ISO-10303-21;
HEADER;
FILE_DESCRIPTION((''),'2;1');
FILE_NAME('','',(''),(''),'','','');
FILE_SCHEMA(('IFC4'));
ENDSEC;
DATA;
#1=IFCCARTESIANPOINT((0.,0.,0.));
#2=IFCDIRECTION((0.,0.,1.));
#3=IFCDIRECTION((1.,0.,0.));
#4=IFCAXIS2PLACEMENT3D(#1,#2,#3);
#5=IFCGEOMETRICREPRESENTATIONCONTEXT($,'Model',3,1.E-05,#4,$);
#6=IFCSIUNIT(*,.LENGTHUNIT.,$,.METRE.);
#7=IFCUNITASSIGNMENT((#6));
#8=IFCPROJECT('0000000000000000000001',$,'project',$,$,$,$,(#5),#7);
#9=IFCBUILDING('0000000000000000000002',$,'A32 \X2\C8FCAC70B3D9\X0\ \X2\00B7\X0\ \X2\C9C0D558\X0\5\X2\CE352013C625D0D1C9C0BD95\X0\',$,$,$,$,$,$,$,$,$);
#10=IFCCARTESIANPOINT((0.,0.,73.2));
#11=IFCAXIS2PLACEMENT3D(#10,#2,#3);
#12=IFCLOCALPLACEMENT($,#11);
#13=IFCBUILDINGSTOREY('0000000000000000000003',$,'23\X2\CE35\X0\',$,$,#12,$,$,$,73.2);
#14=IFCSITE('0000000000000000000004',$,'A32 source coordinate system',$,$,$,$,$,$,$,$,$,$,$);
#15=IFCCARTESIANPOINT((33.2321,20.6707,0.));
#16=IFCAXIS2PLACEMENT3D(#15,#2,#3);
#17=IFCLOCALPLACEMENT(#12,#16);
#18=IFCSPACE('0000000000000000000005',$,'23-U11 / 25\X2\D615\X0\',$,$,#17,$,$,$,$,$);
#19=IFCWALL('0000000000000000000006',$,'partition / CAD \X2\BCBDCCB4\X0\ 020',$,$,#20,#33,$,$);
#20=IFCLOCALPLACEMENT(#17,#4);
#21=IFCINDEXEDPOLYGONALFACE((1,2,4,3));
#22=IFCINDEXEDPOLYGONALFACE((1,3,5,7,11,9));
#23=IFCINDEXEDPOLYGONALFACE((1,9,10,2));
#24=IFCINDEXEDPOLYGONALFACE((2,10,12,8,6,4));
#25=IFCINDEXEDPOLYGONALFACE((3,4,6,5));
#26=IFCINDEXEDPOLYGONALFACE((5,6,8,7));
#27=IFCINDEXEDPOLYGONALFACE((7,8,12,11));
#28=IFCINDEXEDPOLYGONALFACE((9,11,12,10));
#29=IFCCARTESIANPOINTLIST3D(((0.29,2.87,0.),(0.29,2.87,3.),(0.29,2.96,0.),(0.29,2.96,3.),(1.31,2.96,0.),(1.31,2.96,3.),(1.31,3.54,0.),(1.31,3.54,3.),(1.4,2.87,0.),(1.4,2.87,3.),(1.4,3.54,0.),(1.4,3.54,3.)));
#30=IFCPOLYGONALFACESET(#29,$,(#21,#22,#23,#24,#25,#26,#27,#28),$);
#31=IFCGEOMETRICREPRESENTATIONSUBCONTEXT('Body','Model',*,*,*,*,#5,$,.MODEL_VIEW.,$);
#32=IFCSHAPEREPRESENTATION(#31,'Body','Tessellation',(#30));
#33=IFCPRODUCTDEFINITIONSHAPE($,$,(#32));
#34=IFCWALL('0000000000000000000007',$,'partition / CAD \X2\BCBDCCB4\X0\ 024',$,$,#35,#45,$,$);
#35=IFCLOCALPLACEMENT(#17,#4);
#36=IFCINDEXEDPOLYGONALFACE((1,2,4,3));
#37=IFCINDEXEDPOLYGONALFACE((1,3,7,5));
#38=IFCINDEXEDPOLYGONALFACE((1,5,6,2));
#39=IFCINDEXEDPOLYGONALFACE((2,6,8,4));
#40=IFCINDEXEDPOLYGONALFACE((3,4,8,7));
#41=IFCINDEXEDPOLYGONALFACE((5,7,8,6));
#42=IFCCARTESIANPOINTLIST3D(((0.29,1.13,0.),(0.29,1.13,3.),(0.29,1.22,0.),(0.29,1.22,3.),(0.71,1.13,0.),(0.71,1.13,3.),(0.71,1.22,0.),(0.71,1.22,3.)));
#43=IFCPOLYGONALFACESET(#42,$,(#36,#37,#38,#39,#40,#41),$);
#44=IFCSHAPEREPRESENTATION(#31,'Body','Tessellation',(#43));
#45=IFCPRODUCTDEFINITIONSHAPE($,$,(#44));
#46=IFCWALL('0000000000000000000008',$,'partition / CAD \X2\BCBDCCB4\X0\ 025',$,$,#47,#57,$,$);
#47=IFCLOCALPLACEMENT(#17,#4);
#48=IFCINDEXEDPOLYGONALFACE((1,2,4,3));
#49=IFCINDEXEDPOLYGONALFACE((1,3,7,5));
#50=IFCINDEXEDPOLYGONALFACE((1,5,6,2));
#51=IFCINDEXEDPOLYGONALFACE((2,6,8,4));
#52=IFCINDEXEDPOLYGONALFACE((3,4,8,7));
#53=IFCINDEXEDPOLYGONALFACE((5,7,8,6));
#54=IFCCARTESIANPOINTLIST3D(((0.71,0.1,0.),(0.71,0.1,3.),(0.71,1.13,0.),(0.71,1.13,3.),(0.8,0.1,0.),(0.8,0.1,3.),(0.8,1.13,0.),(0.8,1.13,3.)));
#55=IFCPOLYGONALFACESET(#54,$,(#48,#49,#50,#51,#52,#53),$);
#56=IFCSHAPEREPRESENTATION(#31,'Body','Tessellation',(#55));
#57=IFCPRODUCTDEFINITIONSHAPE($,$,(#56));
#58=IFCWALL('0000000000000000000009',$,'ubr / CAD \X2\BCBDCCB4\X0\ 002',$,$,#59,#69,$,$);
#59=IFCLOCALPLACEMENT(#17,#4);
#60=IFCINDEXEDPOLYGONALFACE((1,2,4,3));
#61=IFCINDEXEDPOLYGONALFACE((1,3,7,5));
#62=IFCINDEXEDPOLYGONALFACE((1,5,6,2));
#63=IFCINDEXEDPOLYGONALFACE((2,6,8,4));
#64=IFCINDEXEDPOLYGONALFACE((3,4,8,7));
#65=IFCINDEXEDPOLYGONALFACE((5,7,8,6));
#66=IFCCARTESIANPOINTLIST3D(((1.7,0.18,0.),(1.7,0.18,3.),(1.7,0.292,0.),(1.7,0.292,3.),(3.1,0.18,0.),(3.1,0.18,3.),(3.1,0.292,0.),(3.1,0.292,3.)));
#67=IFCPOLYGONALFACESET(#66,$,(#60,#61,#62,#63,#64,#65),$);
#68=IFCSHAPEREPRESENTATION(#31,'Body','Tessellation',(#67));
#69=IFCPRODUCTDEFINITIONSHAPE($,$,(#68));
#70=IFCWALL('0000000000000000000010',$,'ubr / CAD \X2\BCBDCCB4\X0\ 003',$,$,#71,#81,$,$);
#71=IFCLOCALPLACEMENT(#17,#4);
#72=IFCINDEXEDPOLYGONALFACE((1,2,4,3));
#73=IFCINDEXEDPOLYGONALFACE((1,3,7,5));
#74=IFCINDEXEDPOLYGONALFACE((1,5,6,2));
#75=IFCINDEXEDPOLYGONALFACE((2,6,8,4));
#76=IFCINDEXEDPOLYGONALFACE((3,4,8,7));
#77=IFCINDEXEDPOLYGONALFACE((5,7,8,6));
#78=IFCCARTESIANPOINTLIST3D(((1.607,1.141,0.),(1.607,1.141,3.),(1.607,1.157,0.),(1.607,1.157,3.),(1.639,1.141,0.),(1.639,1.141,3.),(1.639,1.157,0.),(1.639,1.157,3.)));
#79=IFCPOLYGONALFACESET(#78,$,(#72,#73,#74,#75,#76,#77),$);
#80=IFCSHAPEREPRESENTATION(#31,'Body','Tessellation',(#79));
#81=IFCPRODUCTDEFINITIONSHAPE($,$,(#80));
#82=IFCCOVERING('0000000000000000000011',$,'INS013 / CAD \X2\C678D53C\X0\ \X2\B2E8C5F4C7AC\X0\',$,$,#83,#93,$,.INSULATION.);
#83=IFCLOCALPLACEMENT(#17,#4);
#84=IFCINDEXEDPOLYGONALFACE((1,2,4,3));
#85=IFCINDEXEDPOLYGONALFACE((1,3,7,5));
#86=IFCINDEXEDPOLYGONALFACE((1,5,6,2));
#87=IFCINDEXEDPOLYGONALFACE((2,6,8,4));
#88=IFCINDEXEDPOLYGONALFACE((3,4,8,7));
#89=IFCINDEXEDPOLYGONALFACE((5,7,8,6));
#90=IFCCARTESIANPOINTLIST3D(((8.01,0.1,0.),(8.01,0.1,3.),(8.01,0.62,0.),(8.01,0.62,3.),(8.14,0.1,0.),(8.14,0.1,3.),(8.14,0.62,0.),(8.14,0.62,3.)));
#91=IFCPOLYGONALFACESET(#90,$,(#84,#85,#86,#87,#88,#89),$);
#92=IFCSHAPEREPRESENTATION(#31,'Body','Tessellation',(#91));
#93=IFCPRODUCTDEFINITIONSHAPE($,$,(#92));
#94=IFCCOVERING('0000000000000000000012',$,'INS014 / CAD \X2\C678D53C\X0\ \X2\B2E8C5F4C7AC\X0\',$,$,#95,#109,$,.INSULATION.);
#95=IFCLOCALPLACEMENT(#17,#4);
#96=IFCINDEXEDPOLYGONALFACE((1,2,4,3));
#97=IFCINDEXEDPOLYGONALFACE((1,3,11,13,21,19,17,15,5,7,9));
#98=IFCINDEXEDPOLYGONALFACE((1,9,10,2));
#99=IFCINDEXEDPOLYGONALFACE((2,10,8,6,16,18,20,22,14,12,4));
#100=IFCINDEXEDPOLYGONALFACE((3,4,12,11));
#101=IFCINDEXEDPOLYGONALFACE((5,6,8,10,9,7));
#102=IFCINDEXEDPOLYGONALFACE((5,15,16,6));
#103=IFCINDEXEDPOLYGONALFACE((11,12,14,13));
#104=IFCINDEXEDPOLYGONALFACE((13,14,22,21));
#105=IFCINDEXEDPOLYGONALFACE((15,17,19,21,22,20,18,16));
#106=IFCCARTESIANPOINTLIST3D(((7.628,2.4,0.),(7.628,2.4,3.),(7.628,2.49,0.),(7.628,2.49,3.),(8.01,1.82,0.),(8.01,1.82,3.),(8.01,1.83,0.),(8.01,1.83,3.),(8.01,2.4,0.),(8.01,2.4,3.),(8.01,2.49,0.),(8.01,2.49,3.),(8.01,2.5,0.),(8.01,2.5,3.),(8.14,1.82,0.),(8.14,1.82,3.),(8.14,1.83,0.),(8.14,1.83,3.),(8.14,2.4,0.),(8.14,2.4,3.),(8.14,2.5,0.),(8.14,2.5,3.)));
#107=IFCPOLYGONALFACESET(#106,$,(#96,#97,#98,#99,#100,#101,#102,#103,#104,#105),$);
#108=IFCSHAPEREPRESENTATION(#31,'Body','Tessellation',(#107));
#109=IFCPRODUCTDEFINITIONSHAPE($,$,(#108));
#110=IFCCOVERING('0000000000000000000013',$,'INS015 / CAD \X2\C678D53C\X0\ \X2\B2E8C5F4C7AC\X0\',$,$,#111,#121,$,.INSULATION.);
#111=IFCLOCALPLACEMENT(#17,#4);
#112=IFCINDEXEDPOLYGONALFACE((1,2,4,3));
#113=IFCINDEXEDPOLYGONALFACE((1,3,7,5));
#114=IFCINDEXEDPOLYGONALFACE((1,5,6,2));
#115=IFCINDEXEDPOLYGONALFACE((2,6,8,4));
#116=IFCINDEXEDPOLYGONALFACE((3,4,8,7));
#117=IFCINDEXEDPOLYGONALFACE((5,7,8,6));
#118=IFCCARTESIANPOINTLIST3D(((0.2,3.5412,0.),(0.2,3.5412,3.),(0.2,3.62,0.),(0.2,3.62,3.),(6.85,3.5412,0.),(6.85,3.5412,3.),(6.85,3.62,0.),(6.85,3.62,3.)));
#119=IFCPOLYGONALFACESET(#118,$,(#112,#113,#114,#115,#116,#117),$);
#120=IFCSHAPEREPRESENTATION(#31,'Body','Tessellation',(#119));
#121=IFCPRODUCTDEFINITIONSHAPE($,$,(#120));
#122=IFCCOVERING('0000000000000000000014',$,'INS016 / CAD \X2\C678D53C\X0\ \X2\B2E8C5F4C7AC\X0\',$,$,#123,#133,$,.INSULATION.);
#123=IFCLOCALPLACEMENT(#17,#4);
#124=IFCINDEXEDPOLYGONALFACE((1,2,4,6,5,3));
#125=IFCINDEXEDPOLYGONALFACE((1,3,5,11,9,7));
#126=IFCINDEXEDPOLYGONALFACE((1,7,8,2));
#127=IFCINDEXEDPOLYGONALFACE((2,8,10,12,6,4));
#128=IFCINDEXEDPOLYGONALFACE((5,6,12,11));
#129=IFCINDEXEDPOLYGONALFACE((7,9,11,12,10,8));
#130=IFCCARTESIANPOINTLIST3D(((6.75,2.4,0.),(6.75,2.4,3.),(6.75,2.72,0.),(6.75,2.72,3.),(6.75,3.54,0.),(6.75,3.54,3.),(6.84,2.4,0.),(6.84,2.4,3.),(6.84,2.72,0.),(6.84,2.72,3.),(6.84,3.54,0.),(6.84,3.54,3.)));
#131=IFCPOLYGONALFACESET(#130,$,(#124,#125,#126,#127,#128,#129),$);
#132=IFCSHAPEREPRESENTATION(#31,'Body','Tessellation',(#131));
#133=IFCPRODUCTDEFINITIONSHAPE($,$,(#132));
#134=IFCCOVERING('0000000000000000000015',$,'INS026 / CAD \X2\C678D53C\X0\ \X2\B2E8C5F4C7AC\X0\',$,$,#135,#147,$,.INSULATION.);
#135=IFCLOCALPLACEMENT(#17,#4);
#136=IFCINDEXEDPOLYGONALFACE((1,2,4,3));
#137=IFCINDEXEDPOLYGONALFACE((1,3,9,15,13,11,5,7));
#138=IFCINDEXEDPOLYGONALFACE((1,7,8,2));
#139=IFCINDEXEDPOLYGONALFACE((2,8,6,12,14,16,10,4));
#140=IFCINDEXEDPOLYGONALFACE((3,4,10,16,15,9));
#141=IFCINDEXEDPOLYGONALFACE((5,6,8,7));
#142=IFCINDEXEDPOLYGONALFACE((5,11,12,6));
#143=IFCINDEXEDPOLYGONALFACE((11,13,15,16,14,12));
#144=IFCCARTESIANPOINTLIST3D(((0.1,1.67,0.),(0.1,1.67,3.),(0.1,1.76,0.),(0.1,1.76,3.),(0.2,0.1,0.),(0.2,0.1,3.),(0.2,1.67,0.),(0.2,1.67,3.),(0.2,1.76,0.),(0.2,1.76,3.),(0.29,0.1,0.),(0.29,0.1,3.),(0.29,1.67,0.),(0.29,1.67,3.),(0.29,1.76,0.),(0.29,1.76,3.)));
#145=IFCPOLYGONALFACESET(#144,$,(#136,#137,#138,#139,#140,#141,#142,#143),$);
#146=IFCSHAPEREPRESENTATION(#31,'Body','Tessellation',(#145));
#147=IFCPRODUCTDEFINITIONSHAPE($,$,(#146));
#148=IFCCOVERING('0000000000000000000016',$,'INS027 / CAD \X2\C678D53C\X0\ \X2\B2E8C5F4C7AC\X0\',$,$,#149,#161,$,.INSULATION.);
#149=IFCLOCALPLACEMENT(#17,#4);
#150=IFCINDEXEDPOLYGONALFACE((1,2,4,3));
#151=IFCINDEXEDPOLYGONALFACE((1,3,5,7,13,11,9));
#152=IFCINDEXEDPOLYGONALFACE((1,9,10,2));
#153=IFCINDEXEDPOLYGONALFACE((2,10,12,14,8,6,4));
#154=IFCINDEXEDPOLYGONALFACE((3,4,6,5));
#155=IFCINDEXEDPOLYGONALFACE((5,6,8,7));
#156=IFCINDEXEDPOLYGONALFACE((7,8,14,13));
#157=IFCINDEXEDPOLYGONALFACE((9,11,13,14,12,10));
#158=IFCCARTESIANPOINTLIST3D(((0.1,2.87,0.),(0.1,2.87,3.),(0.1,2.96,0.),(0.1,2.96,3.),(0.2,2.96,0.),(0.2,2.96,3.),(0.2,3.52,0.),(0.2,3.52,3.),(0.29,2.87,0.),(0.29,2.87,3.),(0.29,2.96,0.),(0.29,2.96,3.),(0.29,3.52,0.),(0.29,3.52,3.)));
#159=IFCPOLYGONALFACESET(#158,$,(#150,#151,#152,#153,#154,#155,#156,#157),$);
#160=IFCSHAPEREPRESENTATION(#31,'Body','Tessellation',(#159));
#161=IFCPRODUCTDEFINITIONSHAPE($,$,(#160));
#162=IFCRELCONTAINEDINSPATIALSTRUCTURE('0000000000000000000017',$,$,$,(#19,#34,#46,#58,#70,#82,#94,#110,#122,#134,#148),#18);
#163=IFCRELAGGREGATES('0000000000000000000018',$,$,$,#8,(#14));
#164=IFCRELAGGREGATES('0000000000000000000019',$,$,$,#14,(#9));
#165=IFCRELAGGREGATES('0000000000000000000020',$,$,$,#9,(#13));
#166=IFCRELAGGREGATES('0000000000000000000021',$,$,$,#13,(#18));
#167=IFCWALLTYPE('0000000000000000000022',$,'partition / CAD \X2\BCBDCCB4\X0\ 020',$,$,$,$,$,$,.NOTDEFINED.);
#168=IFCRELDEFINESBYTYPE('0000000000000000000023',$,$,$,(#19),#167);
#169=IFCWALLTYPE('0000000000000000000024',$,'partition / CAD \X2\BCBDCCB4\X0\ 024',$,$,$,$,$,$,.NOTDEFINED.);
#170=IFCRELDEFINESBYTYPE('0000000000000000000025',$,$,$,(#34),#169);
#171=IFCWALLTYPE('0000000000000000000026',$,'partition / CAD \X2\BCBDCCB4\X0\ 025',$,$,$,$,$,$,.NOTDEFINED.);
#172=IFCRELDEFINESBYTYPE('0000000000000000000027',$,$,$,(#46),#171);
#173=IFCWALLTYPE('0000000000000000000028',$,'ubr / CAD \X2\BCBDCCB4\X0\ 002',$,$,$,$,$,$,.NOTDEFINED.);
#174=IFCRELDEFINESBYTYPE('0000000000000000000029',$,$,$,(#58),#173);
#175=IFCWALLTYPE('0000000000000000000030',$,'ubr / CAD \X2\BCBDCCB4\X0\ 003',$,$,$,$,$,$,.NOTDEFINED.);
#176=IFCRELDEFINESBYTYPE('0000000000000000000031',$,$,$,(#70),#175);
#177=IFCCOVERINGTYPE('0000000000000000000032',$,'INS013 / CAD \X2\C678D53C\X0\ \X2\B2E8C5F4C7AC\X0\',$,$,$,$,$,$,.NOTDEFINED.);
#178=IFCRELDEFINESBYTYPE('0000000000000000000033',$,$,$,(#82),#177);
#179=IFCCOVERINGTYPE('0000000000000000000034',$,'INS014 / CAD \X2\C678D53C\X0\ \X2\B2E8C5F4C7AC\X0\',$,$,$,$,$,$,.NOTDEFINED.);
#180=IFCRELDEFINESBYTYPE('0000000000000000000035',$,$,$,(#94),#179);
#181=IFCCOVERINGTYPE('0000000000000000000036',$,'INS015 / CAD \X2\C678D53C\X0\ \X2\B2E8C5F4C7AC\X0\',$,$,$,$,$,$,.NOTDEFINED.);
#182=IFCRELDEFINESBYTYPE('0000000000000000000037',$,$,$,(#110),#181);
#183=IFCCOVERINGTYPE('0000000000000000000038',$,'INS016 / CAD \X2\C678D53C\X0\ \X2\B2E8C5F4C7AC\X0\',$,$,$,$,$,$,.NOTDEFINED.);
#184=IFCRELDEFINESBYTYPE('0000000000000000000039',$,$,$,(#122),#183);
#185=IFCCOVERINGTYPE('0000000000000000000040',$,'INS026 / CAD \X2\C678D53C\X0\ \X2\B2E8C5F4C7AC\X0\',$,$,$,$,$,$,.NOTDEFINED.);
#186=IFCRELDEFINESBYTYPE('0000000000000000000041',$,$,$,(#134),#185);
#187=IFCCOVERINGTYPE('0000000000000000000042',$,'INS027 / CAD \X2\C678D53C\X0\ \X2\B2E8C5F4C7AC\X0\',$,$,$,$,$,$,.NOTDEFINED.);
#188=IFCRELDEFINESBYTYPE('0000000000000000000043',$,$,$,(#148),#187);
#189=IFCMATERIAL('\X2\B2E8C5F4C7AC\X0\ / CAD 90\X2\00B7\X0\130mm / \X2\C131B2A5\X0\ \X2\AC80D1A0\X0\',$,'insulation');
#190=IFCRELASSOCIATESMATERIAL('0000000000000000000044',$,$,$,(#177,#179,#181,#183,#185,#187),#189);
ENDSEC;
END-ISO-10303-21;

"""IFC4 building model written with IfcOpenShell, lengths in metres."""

from ifc_helpers import new_model, si_unit, frame, origin, origin_with_axes, place, context, subcontext, project, spatial, polyline, outline, extrude, source, transform, mapped, material, type_object, type_shapes, element, save


model = new_model("IFC4")

# Units and contexts
model_context = context("Model", 3, precision=1e-05, world=origin_with_axes())
body_context = subcontext(model_context, "Body", "Model", "MODEL_VIEW")
ifc_project = project(units=[si_unit("LENGTHUNIT", "METRE")], contexts=[model_context])

# Site, building, storey, space
storey_placement = place(None, frame((0.0, 0.0, 73.2), z_axis=(0.0, 0.0, 1.0), x_axis=(1.0, 0.0, 0.0)))
space_placement = place(storey_placement, frame((33.2321, 20.6707, 0.0), z_axis=(0.0, 0.0, 1.0), x_axis=(1.0, 0.0, 0.0)))
site = spatial("IfcSite", under=ifc_project, Name="A32 source coordinate system")
building = spatial("IfcBuilding", under=site, Name="A32 주거동 · 지하5층–옥탑지붕")
storey = spatial("IfcBuildingStorey", under=building, at=storey_placement, Name="23층", Elevation=73.2)
space = spatial("IfcSpace", under=storey, at=space_placement, Name="23-U11 / 25형")

# Walls
wall_type_1 = type_object("IfcWallType", Name="partition / CAD 벽체 020", PredefinedType="NOTDEFINED")
shared_shape_1 = source(origin(), body_context, "Body", "SweptSolid", [
    extrude(outline(polyline([(0.29, 2.87), (0.29, 2.96), (1.31, 2.96), (1.31, 3.54), (1.4, 3.54), (1.4, 2.87), (0.29, 2.87)])), origin(), (0.0, 0.0, 1.0), 3.0),
])
type_shapes(wall_type_1, [shared_shape_1])
wall_1_placement = place(space_placement, origin_with_axes())
element("IfcWall", 1, at=wall_1_placement, inside=space, type_object=wall_type_1, Name="partition / CAD 벽체 020", context=body_context, shape_type="MappedRepresentation", body=[
    mapped(shared_shape_1, transform((0.0, 0.0, 0.0), scale=1.0)),
])
wall_type_2 = type_object("IfcWallType", Name="partition / CAD 벽체 024", PredefinedType="NOTDEFINED")
shared_shape_2 = source(origin(), body_context, "Body", "SweptSolid", [
    extrude(outline(polyline([(0.71, 1.13), (0.29, 1.13), (0.29, 1.22), (0.71, 1.22), (0.71, 1.13)])), origin(), (0.0, 0.0, 1.0), 3.0),
])
type_shapes(wall_type_2, [shared_shape_2])
wall_2_placement = place(space_placement, origin_with_axes())
element("IfcWall", 2, at=wall_2_placement, inside=space, type_object=wall_type_2, Name="partition / CAD 벽체 024", context=body_context, shape_type="MappedRepresentation", body=[
    mapped(shared_shape_2, transform((0.0, 0.0, 0.0), scale=1.0)),
])
wall_type_3 = type_object("IfcWallType", Name="partition / CAD 벽체 025", PredefinedType="NOTDEFINED")
shared_shape_3 = source(origin(), body_context, "Body", "SweptSolid", [
    extrude(outline(polyline([(0.71, 1.13), (0.8, 1.13), (0.8, 0.1), (0.71, 0.1), (0.71, 1.13)])), origin(), (0.0, 0.0, 1.0), 3.0),
])
type_shapes(wall_type_3, [shared_shape_3])
wall_3_placement = place(space_placement, origin_with_axes())
element("IfcWall", 3, at=wall_3_placement, inside=space, type_object=wall_type_3, Name="partition / CAD 벽체 025", context=body_context, shape_type="MappedRepresentation", body=[
    mapped(shared_shape_3, transform((0.0, 0.0, 0.0), scale=1.0)),
])
wall_type_4 = type_object("IfcWallType", Name="ubr / CAD 벽체 002", PredefinedType="NOTDEFINED")
shared_shape_4 = source(origin(), body_context, "Body", "SweptSolid", [
    extrude(outline(polyline([(3.1, 0.292), (3.1, 0.18), (1.7, 0.18), (1.7, 0.292), (3.1, 0.292)])), origin(), (0.0, 0.0, 1.0), 3.0),
])
type_shapes(wall_type_4, [shared_shape_4])
wall_4_placement = place(space_placement, origin_with_axes())
element("IfcWall", 4, at=wall_4_placement, inside=space, type_object=wall_type_4, Name="ubr / CAD 벽체 002", context=body_context, shape_type="MappedRepresentation", body=[
    mapped(shared_shape_4, transform((0.0, 0.0, 0.0), scale=1.0)),
])
wall_type_5 = type_object("IfcWallType", Name="ubr / CAD 벽체 003", PredefinedType="NOTDEFINED")
shared_shape_5 = source(origin(), body_context, "Body", "SweptSolid", [
    extrude(outline(polyline([(1.639, 1.157), (1.639, 1.141), (1.607, 1.141), (1.607, 1.157), (1.639, 1.157)])), origin(), (0.0, 0.0, 1.0), 3.0),
])
type_shapes(wall_type_5, [shared_shape_5])
wall_5_placement = place(space_placement, origin_with_axes())
element("IfcWall", 5, at=wall_5_placement, inside=space, type_object=wall_type_5, Name="ubr / CAD 벽체 003", context=body_context, shape_type="MappedRepresentation", body=[
    mapped(shared_shape_5, transform((0.0, 0.0, 0.0), scale=1.0)),
])

# Coverings
ifc_material = material(Name="단열재 / CAD 90·130mm / 성능 검토", Category="insulation")
covering_type_1 = type_object("IfcCoveringType", Name="INS013 / CAD 외피 단열재", PredefinedType="NOTDEFINED", material=ifc_material)
shared_shape_6 = source(origin(), body_context, "Body", "SweptSolid", [
    extrude(outline(polyline([(8.14, 0.1), (8.01, 0.1), (8.01, 0.62), (8.14, 0.62), (8.14, 0.1)])), origin(), (0.0, 0.0, 1.0), 3.0),
])
type_shapes(covering_type_1, [shared_shape_6])
covering_1_placement = place(space_placement, origin_with_axes())
element("IfcCovering", 6, at=covering_1_placement, inside=space, type_object=covering_type_1, Name="INS013 / CAD 외피 단열재", PredefinedType="INSULATION", context=body_context, shape_type="MappedRepresentation", body=[
    mapped(shared_shape_6, transform((0.0, 0.0, 0.0), scale=1.0)),
])
covering_type_2 = type_object("IfcCoveringType", Name="INS014 / CAD 외피 단열재", PredefinedType="NOTDEFINED", material=ifc_material)
shared_shape_7 = source(origin(), body_context, "Body", "SweptSolid", [
    extrude(outline(polyline([(8.14, 2.5), (8.14, 2.4), (8.14, 1.83), (8.14, 1.82), (8.01, 1.82), (8.01, 1.83), (8.01, 2.4), (7.628, 2.4), (7.628, 2.49), (8.01, 2.49), (8.01, 2.5), (8.14, 2.5)])), origin(), (0.0, 0.0, 1.0), 3.0),
])
type_shapes(covering_type_2, [shared_shape_7])
covering_2_placement = place(space_placement, origin_with_axes())
element("IfcCovering", 7, at=covering_2_placement, inside=space, type_object=covering_type_2, Name="INS014 / CAD 외피 단열재", PredefinedType="INSULATION", context=body_context, shape_type="MappedRepresentation", body=[
    mapped(shared_shape_7, transform((0.0, 0.0, 0.0), scale=1.0)),
])
covering_type_3 = type_object("IfcCoveringType", Name="INS015 / CAD 외피 단열재", PredefinedType="NOTDEFINED", material=ifc_material)
shared_shape_8 = source(origin(), body_context, "Body", "SweptSolid", [
    extrude(outline(polyline([(0.2, 3.5412), (0.2, 3.62), (6.85, 3.62), (6.85, 3.5412), (0.2, 3.5412)])), origin(), (0.0, 0.0, 1.0), 3.0),
])
type_shapes(covering_type_3, [shared_shape_8])
covering_3_placement = place(space_placement, origin_with_axes())
element("IfcCovering", 8, at=covering_3_placement, inside=space, type_object=covering_type_3, Name="INS015 / CAD 외피 단열재", PredefinedType="INSULATION", context=body_context, shape_type="MappedRepresentation", body=[
    mapped(shared_shape_8, transform((0.0, 0.0, 0.0), scale=1.0)),
])
covering_type_4 = type_object("IfcCoveringType", Name="INS016 / CAD 외피 단열재", PredefinedType="NOTDEFINED", material=ifc_material)
shared_shape_9 = source(origin(), body_context, "Body", "SweptSolid", [
    extrude(outline(polyline([(6.84, 2.72), (6.84, 2.4), (6.75, 2.4), (6.75, 2.72), (6.75, 3.54), (6.84, 3.54), (6.84, 2.72)])), origin(), (0.0, 0.0, 1.0), 3.0),
])
type_shapes(covering_type_4, [shared_shape_9])
covering_4_placement = place(space_placement, origin_with_axes())
element("IfcCovering", 9, at=covering_4_placement, inside=space, type_object=covering_type_4, Name="INS016 / CAD 외피 단열재", PredefinedType="INSULATION", context=body_context, shape_type="MappedRepresentation", body=[
    mapped(shared_shape_9, transform((0.0, 0.0, 0.0), scale=1.0)),
])
covering_type_5 = type_object("IfcCoveringType", Name="INS026 / CAD 외피 단열재", PredefinedType="NOTDEFINED", material=ifc_material)
shared_shape_10 = source(origin(), body_context, "Body", "SweptSolid", [
    extrude(outline(polyline([(0.2, 1.76), (0.29, 1.76), (0.29, 1.67), (0.29, 0.1), (0.2, 0.1), (0.2, 1.67), (0.1, 1.67), (0.1, 1.76), (0.2, 1.76)])), origin(), (0.0, 0.0, 1.0), 3.0),
])
type_shapes(covering_type_5, [shared_shape_10])
covering_5_placement = place(space_placement, origin_with_axes())
element("IfcCovering", 10, at=covering_5_placement, inside=space, type_object=covering_type_5, Name="INS026 / CAD 외피 단열재", PredefinedType="INSULATION", context=body_context, shape_type="MappedRepresentation", body=[
    mapped(shared_shape_10, transform((0.0, 0.0, 0.0), scale=1.0)),
])
covering_type_6 = type_object("IfcCoveringType", Name="INS027 / CAD 외피 단열재", PredefinedType="NOTDEFINED", material=ifc_material)
shared_shape_11 = source(origin(), body_context, "Body", "SweptSolid", [
    extrude(outline(polyline([(0.2, 3.52), (0.29, 3.52), (0.29, 2.96), (0.29, 2.87), (0.1, 2.87), (0.1, 2.96), (0.2, 2.96), (0.2, 3.52)])), origin(), (0.0, 0.0, 1.0), 3.0),
])
type_shapes(covering_type_6, [shared_shape_11])
covering_6_placement = place(space_placement, origin_with_axes())
element("IfcCovering", 11, at=covering_6_placement, inside=space, type_object=covering_type_6, Name="INS027 / CAD 외피 단열재", PredefinedType="INSULATION", context=body_context, shape_type="MappedRepresentation", body=[
    mapped(shared_shape_11, transform((0.0, 0.0, 0.0), scale=1.0)),
])

save(model, "model.ifc")
